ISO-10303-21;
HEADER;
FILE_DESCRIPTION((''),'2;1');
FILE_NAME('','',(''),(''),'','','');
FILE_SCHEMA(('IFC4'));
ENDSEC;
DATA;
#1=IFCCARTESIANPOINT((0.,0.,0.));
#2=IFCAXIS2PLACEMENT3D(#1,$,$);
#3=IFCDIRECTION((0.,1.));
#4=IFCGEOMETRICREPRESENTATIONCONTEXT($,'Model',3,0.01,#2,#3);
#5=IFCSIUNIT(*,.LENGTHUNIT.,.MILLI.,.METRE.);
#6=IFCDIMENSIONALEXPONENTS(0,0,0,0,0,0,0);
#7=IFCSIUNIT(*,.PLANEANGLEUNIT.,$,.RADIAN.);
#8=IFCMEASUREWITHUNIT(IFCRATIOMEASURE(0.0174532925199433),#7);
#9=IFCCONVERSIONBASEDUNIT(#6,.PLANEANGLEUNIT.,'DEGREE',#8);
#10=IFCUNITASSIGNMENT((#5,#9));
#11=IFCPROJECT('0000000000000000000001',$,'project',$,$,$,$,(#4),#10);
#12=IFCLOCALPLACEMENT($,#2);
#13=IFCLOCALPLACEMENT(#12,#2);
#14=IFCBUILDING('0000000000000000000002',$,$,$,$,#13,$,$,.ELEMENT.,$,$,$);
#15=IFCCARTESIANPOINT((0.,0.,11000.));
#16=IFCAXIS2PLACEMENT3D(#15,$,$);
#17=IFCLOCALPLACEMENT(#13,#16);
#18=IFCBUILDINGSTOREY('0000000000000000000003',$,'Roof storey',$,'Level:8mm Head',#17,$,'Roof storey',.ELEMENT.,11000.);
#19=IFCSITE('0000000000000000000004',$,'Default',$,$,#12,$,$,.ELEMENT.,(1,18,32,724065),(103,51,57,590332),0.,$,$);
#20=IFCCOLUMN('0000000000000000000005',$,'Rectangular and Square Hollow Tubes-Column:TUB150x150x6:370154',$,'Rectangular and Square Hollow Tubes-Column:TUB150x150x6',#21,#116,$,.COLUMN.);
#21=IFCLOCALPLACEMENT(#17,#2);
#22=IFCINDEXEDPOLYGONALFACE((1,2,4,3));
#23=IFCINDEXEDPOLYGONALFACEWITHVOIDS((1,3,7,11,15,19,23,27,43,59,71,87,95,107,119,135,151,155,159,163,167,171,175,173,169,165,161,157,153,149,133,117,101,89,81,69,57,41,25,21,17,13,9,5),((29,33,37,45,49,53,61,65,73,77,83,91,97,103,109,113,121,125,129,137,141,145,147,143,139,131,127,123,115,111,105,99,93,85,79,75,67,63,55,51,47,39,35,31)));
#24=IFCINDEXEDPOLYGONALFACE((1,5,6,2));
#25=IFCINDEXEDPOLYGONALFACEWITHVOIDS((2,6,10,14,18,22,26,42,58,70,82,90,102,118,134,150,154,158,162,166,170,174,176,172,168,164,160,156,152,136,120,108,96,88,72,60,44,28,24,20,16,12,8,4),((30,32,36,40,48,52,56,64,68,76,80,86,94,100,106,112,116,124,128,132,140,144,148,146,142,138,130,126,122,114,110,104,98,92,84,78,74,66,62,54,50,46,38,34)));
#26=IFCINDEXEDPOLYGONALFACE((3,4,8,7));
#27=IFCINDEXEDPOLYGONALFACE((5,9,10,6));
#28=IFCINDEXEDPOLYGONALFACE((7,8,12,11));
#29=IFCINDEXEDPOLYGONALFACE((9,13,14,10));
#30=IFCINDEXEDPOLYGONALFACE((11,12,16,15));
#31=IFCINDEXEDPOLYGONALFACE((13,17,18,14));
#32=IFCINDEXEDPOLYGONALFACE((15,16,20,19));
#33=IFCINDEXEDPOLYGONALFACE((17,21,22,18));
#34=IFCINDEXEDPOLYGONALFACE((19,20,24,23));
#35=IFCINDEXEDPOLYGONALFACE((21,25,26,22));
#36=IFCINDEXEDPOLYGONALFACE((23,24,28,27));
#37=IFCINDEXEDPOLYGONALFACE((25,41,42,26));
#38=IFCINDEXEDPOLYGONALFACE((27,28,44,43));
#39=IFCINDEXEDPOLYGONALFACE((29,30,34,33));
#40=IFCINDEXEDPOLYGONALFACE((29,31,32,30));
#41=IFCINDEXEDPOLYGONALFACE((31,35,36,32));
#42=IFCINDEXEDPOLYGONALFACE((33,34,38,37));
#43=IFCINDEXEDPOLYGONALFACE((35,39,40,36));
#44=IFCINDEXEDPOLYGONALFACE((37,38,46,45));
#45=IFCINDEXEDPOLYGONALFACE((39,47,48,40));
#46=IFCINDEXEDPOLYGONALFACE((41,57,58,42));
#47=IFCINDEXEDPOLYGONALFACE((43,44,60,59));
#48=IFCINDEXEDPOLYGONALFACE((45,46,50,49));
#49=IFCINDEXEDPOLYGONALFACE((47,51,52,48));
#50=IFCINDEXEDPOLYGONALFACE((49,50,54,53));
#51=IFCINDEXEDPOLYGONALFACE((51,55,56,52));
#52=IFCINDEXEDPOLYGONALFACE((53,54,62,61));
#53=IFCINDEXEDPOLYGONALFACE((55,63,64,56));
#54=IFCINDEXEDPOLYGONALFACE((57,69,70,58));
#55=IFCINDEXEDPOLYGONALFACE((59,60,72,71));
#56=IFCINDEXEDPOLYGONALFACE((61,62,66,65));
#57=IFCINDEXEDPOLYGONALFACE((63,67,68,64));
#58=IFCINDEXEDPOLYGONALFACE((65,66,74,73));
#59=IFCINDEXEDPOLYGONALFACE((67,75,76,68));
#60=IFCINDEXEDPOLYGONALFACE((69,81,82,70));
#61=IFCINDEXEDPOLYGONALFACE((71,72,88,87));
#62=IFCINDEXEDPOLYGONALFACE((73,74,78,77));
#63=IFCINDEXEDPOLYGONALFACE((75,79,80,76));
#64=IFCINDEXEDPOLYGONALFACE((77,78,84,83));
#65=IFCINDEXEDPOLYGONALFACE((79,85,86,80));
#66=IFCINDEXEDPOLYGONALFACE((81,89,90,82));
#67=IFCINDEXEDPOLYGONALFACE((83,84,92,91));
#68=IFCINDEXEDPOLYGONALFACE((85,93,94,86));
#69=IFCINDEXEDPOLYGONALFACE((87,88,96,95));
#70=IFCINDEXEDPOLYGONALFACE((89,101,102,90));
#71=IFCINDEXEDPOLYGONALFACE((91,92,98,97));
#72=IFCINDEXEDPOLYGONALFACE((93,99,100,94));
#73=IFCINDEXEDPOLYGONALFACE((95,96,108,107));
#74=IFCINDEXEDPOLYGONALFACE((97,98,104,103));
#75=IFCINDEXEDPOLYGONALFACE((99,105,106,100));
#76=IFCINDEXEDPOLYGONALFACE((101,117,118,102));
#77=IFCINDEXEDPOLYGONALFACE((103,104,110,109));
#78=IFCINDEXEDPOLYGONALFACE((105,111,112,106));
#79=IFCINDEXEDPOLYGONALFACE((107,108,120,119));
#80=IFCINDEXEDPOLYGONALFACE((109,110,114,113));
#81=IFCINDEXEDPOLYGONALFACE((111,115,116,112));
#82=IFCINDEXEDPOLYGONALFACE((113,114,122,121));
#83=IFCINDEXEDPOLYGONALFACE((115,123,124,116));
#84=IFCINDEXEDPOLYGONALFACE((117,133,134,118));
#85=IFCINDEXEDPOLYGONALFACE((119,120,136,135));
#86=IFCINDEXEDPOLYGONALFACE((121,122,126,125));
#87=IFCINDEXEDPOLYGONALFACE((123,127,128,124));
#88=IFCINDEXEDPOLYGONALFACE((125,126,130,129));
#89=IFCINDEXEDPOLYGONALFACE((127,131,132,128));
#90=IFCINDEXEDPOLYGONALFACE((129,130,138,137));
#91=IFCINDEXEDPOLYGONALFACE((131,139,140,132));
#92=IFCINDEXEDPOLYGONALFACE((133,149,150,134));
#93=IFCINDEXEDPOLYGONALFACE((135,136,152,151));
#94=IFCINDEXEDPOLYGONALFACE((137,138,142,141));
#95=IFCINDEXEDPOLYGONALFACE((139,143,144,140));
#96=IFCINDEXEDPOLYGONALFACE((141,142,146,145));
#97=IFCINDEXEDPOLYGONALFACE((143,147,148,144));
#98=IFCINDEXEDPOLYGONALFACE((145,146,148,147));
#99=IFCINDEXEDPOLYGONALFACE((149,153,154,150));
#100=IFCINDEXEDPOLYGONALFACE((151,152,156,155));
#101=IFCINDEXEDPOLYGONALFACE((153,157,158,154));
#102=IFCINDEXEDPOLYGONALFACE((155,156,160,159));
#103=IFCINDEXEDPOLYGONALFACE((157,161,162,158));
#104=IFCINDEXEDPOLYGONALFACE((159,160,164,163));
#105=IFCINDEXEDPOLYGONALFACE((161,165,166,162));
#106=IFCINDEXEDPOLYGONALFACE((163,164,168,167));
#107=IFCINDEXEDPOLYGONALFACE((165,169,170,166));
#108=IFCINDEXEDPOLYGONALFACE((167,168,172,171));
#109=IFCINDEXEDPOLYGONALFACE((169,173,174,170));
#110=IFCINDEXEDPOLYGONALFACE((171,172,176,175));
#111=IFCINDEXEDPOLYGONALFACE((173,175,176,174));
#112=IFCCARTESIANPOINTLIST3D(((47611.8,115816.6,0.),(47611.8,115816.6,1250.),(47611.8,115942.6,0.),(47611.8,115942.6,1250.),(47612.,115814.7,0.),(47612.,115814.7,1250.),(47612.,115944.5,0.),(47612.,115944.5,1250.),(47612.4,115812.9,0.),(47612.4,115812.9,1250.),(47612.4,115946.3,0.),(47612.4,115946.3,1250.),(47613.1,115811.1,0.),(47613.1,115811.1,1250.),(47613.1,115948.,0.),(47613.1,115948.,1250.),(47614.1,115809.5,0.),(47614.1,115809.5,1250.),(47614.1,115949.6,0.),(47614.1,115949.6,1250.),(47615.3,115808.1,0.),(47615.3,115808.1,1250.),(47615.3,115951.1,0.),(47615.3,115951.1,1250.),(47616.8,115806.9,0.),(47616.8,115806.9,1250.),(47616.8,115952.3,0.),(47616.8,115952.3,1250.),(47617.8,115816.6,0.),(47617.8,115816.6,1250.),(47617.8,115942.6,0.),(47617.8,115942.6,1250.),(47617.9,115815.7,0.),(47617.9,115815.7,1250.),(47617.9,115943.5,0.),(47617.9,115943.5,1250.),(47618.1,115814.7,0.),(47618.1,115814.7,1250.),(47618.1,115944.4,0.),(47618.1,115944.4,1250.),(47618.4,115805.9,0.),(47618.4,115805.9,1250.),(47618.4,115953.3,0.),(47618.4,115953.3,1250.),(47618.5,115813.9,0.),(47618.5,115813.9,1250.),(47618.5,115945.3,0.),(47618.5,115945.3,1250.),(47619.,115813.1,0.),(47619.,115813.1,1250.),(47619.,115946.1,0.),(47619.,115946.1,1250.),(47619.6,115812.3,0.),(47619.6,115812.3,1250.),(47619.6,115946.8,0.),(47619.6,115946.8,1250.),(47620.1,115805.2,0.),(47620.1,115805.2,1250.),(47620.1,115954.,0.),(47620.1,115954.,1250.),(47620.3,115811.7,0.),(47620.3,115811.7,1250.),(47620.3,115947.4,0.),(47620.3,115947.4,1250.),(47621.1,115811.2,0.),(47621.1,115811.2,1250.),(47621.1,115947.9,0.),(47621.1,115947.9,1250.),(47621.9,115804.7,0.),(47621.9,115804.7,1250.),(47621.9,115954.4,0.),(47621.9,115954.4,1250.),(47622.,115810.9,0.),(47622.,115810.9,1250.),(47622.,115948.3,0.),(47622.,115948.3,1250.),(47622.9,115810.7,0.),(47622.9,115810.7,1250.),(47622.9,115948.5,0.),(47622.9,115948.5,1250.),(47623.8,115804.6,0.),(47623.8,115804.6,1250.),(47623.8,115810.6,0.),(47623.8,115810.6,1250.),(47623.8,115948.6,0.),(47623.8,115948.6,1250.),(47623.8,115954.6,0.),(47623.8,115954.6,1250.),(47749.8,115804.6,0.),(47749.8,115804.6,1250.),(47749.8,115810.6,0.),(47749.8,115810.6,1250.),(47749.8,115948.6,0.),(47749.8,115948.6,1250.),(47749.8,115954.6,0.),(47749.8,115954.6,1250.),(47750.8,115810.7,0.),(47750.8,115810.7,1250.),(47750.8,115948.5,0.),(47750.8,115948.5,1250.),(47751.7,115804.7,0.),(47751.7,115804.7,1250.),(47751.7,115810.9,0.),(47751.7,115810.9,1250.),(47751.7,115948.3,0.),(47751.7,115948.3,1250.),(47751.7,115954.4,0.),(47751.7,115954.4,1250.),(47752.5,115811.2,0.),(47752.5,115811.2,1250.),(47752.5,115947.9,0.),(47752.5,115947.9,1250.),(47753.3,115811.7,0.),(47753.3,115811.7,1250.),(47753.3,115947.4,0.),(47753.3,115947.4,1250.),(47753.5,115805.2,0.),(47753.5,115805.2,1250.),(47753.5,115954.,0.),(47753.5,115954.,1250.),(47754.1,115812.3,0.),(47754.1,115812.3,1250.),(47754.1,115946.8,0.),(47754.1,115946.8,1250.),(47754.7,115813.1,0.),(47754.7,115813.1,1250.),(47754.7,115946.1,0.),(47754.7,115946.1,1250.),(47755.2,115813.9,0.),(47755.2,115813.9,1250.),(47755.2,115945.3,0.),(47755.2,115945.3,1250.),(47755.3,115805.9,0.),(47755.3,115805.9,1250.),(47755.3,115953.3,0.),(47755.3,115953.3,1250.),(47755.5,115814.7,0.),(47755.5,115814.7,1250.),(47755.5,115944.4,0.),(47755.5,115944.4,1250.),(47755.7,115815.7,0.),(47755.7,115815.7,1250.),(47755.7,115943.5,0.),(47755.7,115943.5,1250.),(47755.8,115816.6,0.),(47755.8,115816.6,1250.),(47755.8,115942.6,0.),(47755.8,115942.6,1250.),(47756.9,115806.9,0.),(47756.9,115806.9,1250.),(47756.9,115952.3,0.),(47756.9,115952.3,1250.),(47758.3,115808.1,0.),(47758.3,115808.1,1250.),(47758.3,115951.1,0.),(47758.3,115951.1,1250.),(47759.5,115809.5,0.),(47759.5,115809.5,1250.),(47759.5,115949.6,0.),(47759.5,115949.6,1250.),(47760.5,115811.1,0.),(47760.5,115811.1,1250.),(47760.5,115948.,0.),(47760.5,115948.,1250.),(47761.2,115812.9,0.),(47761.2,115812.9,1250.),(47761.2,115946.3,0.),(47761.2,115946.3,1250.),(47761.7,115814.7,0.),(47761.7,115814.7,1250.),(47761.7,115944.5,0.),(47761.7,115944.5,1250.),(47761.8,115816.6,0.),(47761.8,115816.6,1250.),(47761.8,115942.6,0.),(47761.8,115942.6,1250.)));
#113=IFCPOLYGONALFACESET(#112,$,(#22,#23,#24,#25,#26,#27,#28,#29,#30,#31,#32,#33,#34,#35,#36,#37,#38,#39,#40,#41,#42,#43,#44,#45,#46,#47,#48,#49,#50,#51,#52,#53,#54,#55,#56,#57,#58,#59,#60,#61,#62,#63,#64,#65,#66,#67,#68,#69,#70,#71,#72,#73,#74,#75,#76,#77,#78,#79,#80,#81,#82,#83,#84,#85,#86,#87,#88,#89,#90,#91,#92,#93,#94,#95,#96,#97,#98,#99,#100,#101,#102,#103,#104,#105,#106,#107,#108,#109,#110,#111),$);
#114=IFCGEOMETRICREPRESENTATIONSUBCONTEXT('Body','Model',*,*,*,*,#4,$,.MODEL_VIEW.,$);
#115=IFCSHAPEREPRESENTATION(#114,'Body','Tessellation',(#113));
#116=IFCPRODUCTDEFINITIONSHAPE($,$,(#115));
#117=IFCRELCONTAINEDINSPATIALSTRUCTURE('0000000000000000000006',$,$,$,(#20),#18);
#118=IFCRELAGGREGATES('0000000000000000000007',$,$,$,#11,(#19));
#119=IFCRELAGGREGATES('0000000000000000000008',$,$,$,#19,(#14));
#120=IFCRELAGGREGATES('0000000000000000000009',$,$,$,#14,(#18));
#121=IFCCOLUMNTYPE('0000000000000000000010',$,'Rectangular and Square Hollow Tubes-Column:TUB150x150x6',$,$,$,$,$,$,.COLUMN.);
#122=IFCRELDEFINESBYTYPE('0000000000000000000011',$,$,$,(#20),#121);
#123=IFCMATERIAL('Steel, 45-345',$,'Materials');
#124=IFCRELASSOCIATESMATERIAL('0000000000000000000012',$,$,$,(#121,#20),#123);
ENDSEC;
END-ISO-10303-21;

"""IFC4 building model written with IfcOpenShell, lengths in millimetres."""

from ifc_helpers import new_model, entity, si_unit, converted_unit, direction, frame, origin, place, context, subcontext, project, spatial, indexed_curve, outline, extrude, source, transform, mapped, material, type_object, type_shapes, element, save


model = new_model("IFC4")

# Units and contexts
model_context = context("Model", 3, precision=0.01, world=origin(), true_north=direction((0.0, 1.0)))
body_context = subcontext(model_context, "Body", "Model", "MODEL_VIEW")
ifc_project = project(units=[si_unit("LENGTHUNIT", "METRE", prefix="MILLI"), converted_unit("PLANEANGLEUNIT", "DEGREE", entity("IfcRatioMeasure", 0.0174532925199433), si_unit("PLANEANGLEUNIT", "RADIAN"), dimensions=[0, 0, 0, 0, 0, 0, 0])], contexts=[model_context])

# Site, building, storey
site_placement = place(None, origin())
site = spatial("IfcSite", under=ifc_project, at=site_placement, Name="Default", CompositionType="ELEMENT", RefLatitude=(1, 18, 32, 724065), RefLongitude=(103, 51, 57, 590332), RefElevation=0.0)
building_placement = place(site_placement, origin())
building = spatial("IfcBuilding", under=site, at=building_placement, CompositionType="ELEMENT")
storey_placement = place(building_placement, frame((0.0, 0.0, 11000.0)))
storey = spatial("IfcBuildingStorey", under=building, at=storey_placement, Name="Roof storey", ObjectType="Level:8mm Head", LongName="Roof storey", CompositionType="ELEMENT", Elevation=11000.0)

# Column
ifc_material = material(Name="Steel, 45-345", Category="Materials")
column_type = type_object("IfcColumnType", Name="Rectangular and Square Hollow Tubes-Column:TUB150x150x6", PredefinedType="COLUMN", material=ifc_material)
shared_shape_1 = source(origin(), body_context, "Body", "SweptSolid", [
    extrude(outline(indexed_curve([(-63.0, -75.0), (63.0, -75.0), (64.9, -74.9), (66.7, -74.4), (68.4, -73.7), (70.1, -72.7), (71.5, -71.5), (72.7, -70.1), (73.7, -68.4), (74.4, -66.7), (74.9, -64.9), (75.0, -63.0), (75.0, 63.0), (74.9, 64.9), (74.4, 66.7), (73.7, 68.4), (72.7, 70.1), (71.5, 71.5), (70.1, 72.7), (68.4, 73.7), (66.7, 74.4), (64.9, 74.9), (63.0, 75.0), (-63.0, 75.0), (-64.9, 74.9), (-66.7, 74.4), (-68.4, 73.7), (-70.1, 72.7), (-71.5, 71.5), (-72.7, 70.1), (-73.7, 68.4), (-74.4, 66.7), (-74.9, 64.9), (-75.0, 63.0), (-75.0, -63.0), (-74.9, -64.9), (-74.4, -66.7), (-73.7, -68.4), (-72.7, -70.1), (-71.5, -71.5), (-70.1, -72.7), (-68.4, -73.7), (-66.7, -74.4), (-64.9, -74.9), (-63.0, -75.0)], self_intersect=False), holes=[indexed_curve([(-63.0, -69.0), (-63.9, -68.9), (-64.9, -68.7), (-65.7, -68.3), (-66.5, -67.9), (-67.2, -67.2), (-67.9, -66.5), (-68.3, -65.7), (-68.7, -64.9), (-68.9, -63.9), (-69.0, -63.0), (-69.0, 63.0), (-68.9, 63.9), (-68.7, 64.9), (-68.3, 65.7), (-67.9, 66.5), (-67.2, 67.2), (-66.5, 67.9), (-65.7, 68.3), (-64.9, 68.7), (-63.9, 68.9), (-63.0, 69.0), (63.0, 69.0), (63.9, 68.9), (64.9, 68.7), (65.7, 68.3), (66.5, 67.9), (67.2, 67.2), (67.9, 66.5), (68.3, 65.7), (68.7, 64.9), (68.9, 63.9), (69.0, 63.0), (69.0, -63.0), (68.9, -63.9), (68.7, -64.9), (68.3, -65.7), (67.9, -66.5), (67.2, -67.2), (66.5, -67.9), (65.7, -68.3), (64.9, -68.7), (63.9, -68.9), (63.0, -69.0), (-63.0, -69.0)], self_intersect=False)]), frame((0.0, 0.0, 11000.0), z_axis=(0.0, 0.0, 1.0), x_axis=(-1.0, 0.0, 0.0)), (0.0, 0.0, 1.0), 1250.0),
])
type_shapes(column_type, [shared_shape_1])
for number, where, name in (
    (1, (47686.8, 115879.6, -11000.0), "Rectangular and Square Hollow Tubes-Column:TUB150x150x6:370154"),
):
    element("IfcColumn", number, at=place(storey_placement, frame(where)), inside=storey, type_object=column_type, material=ifc_material, Name=name, ObjectType="Rectangular and Square Hollow Tubes-Column:TUB150x150x6", PredefinedType="COLUMN", context=body_context, shape_type="MappedRepresentation", body=[
        mapped(shared_shape_1, transform((0.0, 0.0, 0.0), scale=1.0)),
    ])

save(model, "model.ifc")
